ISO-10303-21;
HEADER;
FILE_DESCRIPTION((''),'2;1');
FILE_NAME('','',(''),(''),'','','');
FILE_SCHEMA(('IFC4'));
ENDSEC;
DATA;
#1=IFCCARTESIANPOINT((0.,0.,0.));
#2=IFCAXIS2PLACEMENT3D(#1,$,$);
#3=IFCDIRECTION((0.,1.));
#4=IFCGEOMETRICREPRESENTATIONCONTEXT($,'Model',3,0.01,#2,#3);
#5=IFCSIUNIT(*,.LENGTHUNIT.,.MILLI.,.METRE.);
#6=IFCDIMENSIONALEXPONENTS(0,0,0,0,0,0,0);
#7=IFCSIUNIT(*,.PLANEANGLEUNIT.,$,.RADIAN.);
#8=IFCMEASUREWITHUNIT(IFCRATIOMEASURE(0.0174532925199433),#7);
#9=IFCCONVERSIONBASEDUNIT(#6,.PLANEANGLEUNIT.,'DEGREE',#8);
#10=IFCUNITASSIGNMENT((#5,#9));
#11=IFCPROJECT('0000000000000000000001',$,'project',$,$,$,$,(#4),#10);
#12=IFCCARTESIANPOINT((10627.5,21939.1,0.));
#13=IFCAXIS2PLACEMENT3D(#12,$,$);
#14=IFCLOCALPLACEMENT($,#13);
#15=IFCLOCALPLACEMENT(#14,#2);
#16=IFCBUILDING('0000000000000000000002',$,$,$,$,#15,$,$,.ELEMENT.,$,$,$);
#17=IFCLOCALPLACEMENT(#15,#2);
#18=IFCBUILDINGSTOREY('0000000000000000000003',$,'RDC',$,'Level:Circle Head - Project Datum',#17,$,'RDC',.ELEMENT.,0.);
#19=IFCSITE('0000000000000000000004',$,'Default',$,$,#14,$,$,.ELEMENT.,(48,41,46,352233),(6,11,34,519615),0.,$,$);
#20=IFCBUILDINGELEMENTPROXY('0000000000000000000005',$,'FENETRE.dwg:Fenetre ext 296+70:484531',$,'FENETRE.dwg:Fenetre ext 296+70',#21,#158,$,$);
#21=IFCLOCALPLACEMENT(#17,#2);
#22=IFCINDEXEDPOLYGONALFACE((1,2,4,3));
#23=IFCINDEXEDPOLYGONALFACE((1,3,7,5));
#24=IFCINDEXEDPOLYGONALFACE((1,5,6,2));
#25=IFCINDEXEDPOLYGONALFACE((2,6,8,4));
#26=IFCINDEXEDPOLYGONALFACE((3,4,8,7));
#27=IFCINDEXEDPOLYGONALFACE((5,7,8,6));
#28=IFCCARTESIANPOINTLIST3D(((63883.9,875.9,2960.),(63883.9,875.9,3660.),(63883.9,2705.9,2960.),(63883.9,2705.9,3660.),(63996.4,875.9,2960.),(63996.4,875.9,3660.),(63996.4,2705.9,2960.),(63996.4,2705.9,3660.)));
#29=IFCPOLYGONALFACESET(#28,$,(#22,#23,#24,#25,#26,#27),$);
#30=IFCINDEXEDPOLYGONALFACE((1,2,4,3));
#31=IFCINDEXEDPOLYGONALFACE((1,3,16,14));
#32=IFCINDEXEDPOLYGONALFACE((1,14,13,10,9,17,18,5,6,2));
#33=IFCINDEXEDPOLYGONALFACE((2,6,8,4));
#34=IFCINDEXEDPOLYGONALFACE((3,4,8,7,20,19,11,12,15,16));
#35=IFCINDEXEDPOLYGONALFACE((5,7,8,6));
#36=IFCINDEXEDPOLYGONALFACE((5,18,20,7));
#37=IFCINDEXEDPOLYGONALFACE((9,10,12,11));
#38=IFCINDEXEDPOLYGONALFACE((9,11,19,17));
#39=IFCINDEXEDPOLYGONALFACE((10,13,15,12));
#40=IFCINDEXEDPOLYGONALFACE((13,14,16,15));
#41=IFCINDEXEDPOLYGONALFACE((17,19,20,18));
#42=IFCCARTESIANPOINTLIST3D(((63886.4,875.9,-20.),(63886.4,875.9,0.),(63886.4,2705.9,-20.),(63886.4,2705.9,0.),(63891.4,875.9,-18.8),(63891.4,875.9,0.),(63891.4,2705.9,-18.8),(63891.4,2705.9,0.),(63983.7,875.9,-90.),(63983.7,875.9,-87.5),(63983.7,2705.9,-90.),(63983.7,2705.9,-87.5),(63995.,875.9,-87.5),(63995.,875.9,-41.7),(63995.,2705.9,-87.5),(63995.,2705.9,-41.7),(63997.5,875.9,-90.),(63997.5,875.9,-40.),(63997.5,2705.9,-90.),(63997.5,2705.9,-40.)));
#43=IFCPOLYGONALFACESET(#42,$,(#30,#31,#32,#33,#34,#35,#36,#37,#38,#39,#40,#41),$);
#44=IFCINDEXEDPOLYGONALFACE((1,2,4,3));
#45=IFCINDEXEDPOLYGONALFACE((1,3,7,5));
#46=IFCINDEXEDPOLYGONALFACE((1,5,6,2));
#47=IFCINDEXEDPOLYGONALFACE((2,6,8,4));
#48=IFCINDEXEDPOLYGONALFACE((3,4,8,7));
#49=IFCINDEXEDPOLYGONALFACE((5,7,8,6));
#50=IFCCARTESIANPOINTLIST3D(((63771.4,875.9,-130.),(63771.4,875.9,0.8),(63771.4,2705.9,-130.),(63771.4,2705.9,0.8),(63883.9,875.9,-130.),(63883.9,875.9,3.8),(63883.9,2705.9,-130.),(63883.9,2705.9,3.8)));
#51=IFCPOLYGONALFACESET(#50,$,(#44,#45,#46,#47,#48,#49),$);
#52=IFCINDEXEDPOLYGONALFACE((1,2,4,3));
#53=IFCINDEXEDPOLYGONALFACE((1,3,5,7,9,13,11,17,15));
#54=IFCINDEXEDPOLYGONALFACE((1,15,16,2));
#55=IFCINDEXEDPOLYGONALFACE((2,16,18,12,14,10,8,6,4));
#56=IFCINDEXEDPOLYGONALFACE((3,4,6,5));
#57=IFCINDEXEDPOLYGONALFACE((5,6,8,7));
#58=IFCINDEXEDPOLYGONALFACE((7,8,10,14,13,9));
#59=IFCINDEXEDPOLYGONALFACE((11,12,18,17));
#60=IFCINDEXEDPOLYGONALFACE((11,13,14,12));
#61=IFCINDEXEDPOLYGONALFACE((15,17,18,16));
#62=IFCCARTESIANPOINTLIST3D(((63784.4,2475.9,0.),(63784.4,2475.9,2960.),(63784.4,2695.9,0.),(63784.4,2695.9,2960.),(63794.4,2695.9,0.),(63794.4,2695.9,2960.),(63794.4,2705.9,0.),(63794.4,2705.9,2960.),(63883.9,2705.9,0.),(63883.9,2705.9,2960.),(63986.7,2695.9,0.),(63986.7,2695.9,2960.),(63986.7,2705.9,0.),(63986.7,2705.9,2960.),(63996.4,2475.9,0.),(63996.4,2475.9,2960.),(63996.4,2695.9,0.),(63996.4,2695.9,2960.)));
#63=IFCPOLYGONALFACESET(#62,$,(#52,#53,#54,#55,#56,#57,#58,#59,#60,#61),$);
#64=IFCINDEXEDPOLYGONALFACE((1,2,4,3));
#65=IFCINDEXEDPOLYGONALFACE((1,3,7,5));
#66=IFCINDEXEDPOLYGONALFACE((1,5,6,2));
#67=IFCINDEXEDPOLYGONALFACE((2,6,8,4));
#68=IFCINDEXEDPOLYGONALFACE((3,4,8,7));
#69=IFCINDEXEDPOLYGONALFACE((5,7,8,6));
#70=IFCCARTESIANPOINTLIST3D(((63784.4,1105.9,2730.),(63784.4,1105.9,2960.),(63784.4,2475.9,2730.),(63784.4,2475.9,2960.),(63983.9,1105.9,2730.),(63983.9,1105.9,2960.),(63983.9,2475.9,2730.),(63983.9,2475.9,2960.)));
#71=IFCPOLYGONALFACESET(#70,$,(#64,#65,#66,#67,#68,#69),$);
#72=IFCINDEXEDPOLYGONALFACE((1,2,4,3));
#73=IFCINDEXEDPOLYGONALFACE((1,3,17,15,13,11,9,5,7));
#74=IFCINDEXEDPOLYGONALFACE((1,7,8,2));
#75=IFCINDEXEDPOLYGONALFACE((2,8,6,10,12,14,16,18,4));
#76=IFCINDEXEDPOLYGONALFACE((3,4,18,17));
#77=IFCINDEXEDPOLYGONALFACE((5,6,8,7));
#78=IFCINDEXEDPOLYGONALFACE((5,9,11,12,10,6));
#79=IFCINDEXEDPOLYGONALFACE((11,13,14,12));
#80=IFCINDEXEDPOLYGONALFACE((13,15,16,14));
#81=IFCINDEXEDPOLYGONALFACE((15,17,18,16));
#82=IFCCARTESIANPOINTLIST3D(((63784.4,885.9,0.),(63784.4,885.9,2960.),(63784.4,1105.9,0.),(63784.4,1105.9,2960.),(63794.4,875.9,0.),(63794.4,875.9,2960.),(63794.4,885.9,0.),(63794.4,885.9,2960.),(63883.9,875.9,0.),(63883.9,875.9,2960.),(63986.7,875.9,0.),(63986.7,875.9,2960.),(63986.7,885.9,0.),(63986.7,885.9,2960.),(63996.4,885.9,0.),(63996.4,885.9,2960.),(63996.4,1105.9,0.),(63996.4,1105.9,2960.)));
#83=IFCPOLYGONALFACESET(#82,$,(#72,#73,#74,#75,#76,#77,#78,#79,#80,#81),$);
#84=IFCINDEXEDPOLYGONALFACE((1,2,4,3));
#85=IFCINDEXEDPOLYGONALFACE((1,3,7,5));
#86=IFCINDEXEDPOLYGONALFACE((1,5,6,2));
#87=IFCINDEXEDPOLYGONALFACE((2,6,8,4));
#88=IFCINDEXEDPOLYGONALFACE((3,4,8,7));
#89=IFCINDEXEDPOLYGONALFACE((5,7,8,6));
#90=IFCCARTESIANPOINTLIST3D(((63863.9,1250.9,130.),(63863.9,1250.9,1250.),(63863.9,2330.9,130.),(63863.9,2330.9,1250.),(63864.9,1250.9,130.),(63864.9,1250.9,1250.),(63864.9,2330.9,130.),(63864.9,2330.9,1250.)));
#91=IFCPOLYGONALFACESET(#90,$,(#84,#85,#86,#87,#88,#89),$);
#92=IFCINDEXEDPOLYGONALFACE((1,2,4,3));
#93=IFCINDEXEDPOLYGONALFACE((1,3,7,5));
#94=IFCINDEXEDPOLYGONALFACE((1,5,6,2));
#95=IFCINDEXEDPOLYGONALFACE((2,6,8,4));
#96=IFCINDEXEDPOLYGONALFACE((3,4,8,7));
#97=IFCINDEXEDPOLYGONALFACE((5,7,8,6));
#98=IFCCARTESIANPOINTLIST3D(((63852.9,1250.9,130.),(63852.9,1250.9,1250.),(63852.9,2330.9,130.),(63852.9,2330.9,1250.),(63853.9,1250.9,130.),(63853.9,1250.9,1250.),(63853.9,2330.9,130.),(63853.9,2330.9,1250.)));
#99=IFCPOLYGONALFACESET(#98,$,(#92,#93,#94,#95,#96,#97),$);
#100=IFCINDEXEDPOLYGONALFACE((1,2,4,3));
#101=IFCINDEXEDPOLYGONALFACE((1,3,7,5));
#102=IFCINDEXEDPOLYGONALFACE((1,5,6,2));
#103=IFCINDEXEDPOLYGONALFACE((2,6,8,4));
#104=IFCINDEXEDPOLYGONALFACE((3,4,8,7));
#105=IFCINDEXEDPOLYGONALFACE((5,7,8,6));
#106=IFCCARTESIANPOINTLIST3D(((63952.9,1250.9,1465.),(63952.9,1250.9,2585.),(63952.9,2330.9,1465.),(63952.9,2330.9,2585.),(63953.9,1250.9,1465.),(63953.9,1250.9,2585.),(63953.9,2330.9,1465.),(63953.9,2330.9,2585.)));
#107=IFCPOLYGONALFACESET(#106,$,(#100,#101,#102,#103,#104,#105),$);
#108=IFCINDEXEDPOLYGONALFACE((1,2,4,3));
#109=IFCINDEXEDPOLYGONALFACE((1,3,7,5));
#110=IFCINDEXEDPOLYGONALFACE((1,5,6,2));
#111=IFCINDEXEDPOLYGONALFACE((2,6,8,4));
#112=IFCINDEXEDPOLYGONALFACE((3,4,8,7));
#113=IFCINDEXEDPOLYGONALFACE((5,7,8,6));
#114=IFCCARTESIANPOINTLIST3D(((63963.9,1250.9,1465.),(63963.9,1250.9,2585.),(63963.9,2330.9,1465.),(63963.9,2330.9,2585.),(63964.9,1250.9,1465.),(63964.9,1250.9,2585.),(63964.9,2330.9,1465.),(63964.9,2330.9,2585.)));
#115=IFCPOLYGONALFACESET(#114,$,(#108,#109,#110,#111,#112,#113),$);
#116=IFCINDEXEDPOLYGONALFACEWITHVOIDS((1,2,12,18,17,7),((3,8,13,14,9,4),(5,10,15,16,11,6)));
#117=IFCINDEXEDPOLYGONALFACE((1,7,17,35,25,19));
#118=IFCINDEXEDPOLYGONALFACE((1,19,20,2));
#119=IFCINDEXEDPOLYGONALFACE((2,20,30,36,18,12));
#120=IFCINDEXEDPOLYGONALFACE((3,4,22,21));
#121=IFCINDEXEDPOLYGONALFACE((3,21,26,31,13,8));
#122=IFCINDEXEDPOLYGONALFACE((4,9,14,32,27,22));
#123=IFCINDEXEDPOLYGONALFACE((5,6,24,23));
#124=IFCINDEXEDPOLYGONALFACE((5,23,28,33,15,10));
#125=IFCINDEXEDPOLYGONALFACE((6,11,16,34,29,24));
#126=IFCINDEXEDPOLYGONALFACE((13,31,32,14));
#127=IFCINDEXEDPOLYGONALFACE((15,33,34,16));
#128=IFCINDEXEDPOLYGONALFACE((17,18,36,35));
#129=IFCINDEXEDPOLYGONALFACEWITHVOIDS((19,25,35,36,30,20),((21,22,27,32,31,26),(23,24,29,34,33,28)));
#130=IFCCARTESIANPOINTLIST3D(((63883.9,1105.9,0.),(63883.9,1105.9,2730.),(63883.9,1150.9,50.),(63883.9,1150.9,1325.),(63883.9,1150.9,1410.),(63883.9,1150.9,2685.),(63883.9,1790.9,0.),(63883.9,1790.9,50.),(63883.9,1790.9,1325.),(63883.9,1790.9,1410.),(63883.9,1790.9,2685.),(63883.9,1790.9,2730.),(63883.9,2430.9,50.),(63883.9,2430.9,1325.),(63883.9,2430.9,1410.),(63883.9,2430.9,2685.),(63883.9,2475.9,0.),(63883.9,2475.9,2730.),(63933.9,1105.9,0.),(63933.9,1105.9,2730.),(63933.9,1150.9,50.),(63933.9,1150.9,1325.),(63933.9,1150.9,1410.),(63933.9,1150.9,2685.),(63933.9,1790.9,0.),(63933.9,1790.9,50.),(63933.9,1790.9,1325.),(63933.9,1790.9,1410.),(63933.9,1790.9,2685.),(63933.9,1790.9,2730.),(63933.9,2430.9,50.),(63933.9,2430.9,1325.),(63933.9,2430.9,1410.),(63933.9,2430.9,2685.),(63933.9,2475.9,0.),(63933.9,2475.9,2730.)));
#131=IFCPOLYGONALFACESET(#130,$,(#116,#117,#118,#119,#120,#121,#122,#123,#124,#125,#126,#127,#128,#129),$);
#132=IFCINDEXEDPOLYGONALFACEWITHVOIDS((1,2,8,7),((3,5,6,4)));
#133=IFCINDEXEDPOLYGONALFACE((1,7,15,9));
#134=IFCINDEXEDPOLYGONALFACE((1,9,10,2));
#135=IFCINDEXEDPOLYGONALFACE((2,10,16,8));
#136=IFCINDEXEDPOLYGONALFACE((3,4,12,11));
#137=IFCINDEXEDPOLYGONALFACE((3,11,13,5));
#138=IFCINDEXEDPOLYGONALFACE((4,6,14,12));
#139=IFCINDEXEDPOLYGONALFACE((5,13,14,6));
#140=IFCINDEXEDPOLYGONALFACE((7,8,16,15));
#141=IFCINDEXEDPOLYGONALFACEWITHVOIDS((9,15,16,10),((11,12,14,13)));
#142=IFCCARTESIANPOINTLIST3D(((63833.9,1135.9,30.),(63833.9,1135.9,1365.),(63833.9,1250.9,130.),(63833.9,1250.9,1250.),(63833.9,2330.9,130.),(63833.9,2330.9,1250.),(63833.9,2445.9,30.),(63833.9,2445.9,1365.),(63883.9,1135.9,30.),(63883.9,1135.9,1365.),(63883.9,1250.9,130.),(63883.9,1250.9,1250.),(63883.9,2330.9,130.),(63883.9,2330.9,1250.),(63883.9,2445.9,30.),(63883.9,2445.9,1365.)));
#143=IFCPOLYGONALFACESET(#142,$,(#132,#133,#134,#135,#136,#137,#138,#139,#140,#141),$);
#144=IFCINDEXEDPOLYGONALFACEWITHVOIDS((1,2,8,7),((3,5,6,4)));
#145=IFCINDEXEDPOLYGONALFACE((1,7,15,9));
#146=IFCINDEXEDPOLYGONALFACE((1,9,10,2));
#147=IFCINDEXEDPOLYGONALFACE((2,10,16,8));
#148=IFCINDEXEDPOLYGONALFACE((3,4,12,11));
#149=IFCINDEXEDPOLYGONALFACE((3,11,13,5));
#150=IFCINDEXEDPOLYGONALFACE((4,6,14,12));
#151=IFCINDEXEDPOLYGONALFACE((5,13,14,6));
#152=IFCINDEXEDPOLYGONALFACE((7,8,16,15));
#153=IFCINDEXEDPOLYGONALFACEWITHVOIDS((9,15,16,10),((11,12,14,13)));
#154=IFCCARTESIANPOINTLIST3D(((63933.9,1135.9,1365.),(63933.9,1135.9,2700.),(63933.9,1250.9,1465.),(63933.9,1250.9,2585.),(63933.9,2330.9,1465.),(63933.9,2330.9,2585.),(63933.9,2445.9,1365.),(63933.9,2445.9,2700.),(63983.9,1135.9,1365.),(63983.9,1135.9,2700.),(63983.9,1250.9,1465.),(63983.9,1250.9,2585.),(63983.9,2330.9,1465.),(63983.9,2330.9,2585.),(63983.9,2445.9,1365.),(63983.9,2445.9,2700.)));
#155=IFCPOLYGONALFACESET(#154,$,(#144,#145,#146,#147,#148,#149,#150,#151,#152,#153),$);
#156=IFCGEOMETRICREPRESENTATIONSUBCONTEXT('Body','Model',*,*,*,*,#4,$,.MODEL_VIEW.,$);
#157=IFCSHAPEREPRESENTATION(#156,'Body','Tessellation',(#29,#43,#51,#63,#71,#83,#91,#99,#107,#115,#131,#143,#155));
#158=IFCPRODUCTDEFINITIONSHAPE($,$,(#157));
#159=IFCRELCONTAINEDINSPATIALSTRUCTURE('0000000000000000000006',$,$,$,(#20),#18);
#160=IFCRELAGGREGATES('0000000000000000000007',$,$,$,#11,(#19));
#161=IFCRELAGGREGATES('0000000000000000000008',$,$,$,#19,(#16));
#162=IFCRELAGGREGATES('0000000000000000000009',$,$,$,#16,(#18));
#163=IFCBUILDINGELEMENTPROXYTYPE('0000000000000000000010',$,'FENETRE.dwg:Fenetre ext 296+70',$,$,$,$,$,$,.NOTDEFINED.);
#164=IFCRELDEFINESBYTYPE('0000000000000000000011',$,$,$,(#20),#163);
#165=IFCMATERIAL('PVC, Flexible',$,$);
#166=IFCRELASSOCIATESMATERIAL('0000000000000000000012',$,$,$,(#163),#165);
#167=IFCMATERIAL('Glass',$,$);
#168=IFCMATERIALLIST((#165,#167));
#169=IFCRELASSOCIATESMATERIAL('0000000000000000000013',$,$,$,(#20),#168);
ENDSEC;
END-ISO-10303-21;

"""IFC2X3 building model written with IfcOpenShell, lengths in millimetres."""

from ifc_helpers import new_model, entity, si_unit, converted_unit, direction, frame, frame_2d, origin, origin_2d_with_axis, place, context, subcontext, project, spatial, polyline, rectangle, outline, extrude, source, transform, mapped, material, material_list, type_object, type_shapes, element, save


model = new_model("IFC2X3")

# Units and contexts
model_context = context("Model", 3, precision=0.01, world=origin(), true_north=direction((0.0, 1.0)))
body_context = subcontext(model_context, "Body", "Model", "MODEL_VIEW")
ifc_project = project(units=[si_unit("LENGTHUNIT", "METRE", prefix="MILLI"), converted_unit("PLANEANGLEUNIT", "DEGREE", entity("IfcRatioMeasure", 0.0174532925199433), si_unit("PLANEANGLEUNIT", "RADIAN"), dimensions=[0, 0, 0, 0, 0, 0, 0])], contexts=[model_context])

# Site, building, storey
site_placement = place(None, frame((10627.5, 21939.1, 0.0)))
site = spatial("IfcSite", under=ifc_project, at=site_placement, Name="Default", CompositionType="ELEMENT", RefLatitude=(48, 41, 46, 352233), RefLongitude=(6, 11, 34, 519615), RefElevation=0.0)
building_placement = place(site_placement, origin())
building = spatial("IfcBuilding", under=site, at=building_placement, CompositionType="ELEMENT")
storey_placement = place(building_placement, origin())
storey = spatial("IfcBuildingStorey", under=building, at=storey_placement, Name="RDC", ObjectType="Level:Circle Head - Project Datum", LongName="RDC", CompositionType="ELEMENT", Elevation=0.0)

# Building element proxy
ifc_material_1 = material(Name="PVC, Flexible")
ifc_material_2 = material(Name="Glass")
building_element_proxy_type_1 = type_object("IfcBuildingElementProxyType", Name="FENETRE.dwg:Fenetre ext 296+70", PredefinedType="NOTDEFINED", material=ifc_material_1)
shared_shape_1 = source(origin(), body_context, "Body", "SweptSolid", [
    extrude(rectangle(XDim=112.5, YDim=1830.0, at=origin_2d_with_axis()), frame((-10.4, -56.3, 2960.0), z_axis=(0.0, 0.0, 1.0), x_axis=(0.0, 1.0, 0.0)), (0.0, 0.0, 1.0), 700.0),
    extrude(outline(polyline([(27.5, -64.4), (47.5, -64.4), (47.5, -59.4), (28.8, -59.4), (7.5, 46.7), (-42.5, 46.7), (-42.5, 32.9), (-40.0, 32.9), (-40.0, 44.2), (5.8, 44.2), (27.5, -64.4)])), frame((-925.4, -66.9, -47.5), z_axis=(1.0, 0.0, 0.0), x_axis=(0.0, 0.0, 1.0)), (0.0, 0.0, 1.0), 1830.0),
    extrude(outline(polyline([(-54.5, -66.1), (58.0, -66.1), (54.5, 67.6), (-58.0, 64.6), (-54.5, -66.1)])), frame((-925.4, 56.3, -63.8), z_axis=(1.0, 0.0, 0.0), x_axis=(0.0, -0.999645, 0.02665)), (0.0, 0.0, 1.0), 1830.0),
    extrude(outline(polyline([(-97.0, -55.6), (5.9, -55.6), (95.4, -55.6), (95.4, -45.6), (105.4, -45.6), (105.4, 174.4), (-106.6, 174.4), (-106.6, -45.6), (-97.0, -45.6), (-97.0, -55.6)])), frame((849.0, -5.9, 0.0), z_axis=(0.0, 0.0, 1.0), x_axis=(0.0, 1.0, 0.0)), (0.0, 0.0, 1.0), 2960.0),
    extrude(rectangle(XDim=1370.0, YDim=199.5, at=origin_2d_with_axis()), frame((-10.4, -0.3, 2730.0), z_axis=(0.0, 0.0, 1.0), x_axis=(-1.0, 0.0, 0.0)), (0.0, 0.0, 1.0), 230.0),
    extrude(outline(polyline([(-55.6, 97.0), (-55.6, -5.9), (-55.6, -95.4), (-45.6, -95.4), (-45.6, -105.4), (174.4, -105.4), (174.4, 106.6), (-45.6, 106.6), (-45.6, 97.0), (-55.6, 97.0)])), frame((-869.9, -5.9, 0.0), z_axis=(0.0, 0.0, -1.0), x_axis=(1.0, 0.0, 0.0)), (0.0, 0.0, -1.0), 2960.0),
    extrude(rectangle(XDim=1080.0, YDim=1.0, at=origin_2d_with_axis()), frame((-10.4, 19.5, 130.0), z_axis=(0.0, 0.0, 1.0), x_axis=(-1.0, 0.0, 0.0)), (0.0, 0.0, 1.0), 1120.0),
    extrude(rectangle(XDim=1080.0, YDim=1.0, at=origin_2d_with_axis()), frame((-10.4, 30.5, 130.0), z_axis=(0.0, 0.0, 1.0), x_axis=(-1.0, 0.0, 0.0)), (0.0, 0.0, 1.0), 1120.0),
    extrude(rectangle(XDim=1080.0, YDim=1.0, at=frame_2d((0.0, 0.0), x_axis=(1.0, 0.0))), frame((-10.4, -69.5, 1465.0), z_axis=(0.0, 0.0, 1.0), x_axis=(-1.0, 0.0, 0.0)), (0.0, 0.0, 1.0), 1120.0),
    extrude(rectangle(XDim=1080.0, YDim=1.0, at=frame_2d((0.0, 0.0), x_axis=(1.0, 0.0))), frame((-10.4, -80.5, 1465.0), z_axis=(0.0, 0.0, 1.0), x_axis=(-1.0, 0.0, 0.0)), (0.0, 0.0, 1.0), 1120.0),
    extrude(outline(polyline([(-685.0, -1365.0), (0.0, -1365.0), (685.0, -1365.0), (685.0, 1365.0), (0.0, 1365.0), (-685.0, 1365.0), (-685.0, -1365.0)]), holes=[polyline([(-640.0, -1320.0), (-640.0, -45.0), (0.0, -45.0), (640.0, -45.0), (640.0, -1320.0), (0.0, -1320.0), (-640.0, -1320.0)]), polyline([(-640.0, 40.0), (-640.0, 1315.0), (0.0, 1315.0), (640.0, 1315.0), (640.0, 40.0), (0.0, 40.0), (-640.0, 40.0)])]), frame((-10.4, -50.0, 1365.0), z_axis=(0.0, 1.0, 0.0), x_axis=(1.0, 0.0, 0.0)), (0.0, 0.0, 1.0), 50.0),
    extrude(outline(polyline([(-655.0, -667.5), (655.0, -667.5), (655.0, 667.5), (-655.0, 667.5), (-655.0, -667.5)]), holes=[polyline([(-540.0, 552.5), (540.0, 552.5), (540.0, -567.5), (-540.0, -567.5), (-540.0, 552.5)])]), frame((-10.4, 0.0, 697.5), z_axis=(0.0, 1.0, 0.0), x_axis=(-1.0, 0.0, 0.0)), (0.0, 0.0, 1.0), 50.0),
    extrude(outline(polyline([(-655.0, -667.5), (655.0, -667.5), (655.0, 667.5), (-655.0, 667.5), (-655.0, -667.5)]), holes=[polyline([(-540.0, 552.5), (540.0, 552.5), (540.0, -567.5), (-540.0, -567.5), (-540.0, 552.5)])]), frame((-10.4, -100.0, 2032.5), z_axis=(0.0, 1.0, 0.0), x_axis=(-1.0, 0.0, 0.0)), (0.0, 0.0, 1.0), 50.0),
])
type_shapes(building_element_proxy_type_1, [shared_shape_1])
ifc_material_list_1 = material_list([ifc_material_1, ifc_material_2])
proxy_1_placement = place(storey_placement, frame((63883.9, 1801.3, 0.0), z_axis=(0.0, 0.0, 1.0), x_axis=(0.0, 1.0, 0.0)))
element("IfcBuildingElementProxy", 1, at=proxy_1_placement, inside=storey, type_object=building_element_proxy_type_1, material=ifc_material_list_1, Name="FENETRE.dwg:Fenetre ext 296+70:484531", ObjectType="FENETRE.dwg:Fenetre ext 296+70", context=body_context, shape_type="MappedRepresentation", body=[
    mapped(shared_shape_1, transform((0.0, 0.0, 0.0), scale=1.0)),
])

save(model, "model.ifc")
